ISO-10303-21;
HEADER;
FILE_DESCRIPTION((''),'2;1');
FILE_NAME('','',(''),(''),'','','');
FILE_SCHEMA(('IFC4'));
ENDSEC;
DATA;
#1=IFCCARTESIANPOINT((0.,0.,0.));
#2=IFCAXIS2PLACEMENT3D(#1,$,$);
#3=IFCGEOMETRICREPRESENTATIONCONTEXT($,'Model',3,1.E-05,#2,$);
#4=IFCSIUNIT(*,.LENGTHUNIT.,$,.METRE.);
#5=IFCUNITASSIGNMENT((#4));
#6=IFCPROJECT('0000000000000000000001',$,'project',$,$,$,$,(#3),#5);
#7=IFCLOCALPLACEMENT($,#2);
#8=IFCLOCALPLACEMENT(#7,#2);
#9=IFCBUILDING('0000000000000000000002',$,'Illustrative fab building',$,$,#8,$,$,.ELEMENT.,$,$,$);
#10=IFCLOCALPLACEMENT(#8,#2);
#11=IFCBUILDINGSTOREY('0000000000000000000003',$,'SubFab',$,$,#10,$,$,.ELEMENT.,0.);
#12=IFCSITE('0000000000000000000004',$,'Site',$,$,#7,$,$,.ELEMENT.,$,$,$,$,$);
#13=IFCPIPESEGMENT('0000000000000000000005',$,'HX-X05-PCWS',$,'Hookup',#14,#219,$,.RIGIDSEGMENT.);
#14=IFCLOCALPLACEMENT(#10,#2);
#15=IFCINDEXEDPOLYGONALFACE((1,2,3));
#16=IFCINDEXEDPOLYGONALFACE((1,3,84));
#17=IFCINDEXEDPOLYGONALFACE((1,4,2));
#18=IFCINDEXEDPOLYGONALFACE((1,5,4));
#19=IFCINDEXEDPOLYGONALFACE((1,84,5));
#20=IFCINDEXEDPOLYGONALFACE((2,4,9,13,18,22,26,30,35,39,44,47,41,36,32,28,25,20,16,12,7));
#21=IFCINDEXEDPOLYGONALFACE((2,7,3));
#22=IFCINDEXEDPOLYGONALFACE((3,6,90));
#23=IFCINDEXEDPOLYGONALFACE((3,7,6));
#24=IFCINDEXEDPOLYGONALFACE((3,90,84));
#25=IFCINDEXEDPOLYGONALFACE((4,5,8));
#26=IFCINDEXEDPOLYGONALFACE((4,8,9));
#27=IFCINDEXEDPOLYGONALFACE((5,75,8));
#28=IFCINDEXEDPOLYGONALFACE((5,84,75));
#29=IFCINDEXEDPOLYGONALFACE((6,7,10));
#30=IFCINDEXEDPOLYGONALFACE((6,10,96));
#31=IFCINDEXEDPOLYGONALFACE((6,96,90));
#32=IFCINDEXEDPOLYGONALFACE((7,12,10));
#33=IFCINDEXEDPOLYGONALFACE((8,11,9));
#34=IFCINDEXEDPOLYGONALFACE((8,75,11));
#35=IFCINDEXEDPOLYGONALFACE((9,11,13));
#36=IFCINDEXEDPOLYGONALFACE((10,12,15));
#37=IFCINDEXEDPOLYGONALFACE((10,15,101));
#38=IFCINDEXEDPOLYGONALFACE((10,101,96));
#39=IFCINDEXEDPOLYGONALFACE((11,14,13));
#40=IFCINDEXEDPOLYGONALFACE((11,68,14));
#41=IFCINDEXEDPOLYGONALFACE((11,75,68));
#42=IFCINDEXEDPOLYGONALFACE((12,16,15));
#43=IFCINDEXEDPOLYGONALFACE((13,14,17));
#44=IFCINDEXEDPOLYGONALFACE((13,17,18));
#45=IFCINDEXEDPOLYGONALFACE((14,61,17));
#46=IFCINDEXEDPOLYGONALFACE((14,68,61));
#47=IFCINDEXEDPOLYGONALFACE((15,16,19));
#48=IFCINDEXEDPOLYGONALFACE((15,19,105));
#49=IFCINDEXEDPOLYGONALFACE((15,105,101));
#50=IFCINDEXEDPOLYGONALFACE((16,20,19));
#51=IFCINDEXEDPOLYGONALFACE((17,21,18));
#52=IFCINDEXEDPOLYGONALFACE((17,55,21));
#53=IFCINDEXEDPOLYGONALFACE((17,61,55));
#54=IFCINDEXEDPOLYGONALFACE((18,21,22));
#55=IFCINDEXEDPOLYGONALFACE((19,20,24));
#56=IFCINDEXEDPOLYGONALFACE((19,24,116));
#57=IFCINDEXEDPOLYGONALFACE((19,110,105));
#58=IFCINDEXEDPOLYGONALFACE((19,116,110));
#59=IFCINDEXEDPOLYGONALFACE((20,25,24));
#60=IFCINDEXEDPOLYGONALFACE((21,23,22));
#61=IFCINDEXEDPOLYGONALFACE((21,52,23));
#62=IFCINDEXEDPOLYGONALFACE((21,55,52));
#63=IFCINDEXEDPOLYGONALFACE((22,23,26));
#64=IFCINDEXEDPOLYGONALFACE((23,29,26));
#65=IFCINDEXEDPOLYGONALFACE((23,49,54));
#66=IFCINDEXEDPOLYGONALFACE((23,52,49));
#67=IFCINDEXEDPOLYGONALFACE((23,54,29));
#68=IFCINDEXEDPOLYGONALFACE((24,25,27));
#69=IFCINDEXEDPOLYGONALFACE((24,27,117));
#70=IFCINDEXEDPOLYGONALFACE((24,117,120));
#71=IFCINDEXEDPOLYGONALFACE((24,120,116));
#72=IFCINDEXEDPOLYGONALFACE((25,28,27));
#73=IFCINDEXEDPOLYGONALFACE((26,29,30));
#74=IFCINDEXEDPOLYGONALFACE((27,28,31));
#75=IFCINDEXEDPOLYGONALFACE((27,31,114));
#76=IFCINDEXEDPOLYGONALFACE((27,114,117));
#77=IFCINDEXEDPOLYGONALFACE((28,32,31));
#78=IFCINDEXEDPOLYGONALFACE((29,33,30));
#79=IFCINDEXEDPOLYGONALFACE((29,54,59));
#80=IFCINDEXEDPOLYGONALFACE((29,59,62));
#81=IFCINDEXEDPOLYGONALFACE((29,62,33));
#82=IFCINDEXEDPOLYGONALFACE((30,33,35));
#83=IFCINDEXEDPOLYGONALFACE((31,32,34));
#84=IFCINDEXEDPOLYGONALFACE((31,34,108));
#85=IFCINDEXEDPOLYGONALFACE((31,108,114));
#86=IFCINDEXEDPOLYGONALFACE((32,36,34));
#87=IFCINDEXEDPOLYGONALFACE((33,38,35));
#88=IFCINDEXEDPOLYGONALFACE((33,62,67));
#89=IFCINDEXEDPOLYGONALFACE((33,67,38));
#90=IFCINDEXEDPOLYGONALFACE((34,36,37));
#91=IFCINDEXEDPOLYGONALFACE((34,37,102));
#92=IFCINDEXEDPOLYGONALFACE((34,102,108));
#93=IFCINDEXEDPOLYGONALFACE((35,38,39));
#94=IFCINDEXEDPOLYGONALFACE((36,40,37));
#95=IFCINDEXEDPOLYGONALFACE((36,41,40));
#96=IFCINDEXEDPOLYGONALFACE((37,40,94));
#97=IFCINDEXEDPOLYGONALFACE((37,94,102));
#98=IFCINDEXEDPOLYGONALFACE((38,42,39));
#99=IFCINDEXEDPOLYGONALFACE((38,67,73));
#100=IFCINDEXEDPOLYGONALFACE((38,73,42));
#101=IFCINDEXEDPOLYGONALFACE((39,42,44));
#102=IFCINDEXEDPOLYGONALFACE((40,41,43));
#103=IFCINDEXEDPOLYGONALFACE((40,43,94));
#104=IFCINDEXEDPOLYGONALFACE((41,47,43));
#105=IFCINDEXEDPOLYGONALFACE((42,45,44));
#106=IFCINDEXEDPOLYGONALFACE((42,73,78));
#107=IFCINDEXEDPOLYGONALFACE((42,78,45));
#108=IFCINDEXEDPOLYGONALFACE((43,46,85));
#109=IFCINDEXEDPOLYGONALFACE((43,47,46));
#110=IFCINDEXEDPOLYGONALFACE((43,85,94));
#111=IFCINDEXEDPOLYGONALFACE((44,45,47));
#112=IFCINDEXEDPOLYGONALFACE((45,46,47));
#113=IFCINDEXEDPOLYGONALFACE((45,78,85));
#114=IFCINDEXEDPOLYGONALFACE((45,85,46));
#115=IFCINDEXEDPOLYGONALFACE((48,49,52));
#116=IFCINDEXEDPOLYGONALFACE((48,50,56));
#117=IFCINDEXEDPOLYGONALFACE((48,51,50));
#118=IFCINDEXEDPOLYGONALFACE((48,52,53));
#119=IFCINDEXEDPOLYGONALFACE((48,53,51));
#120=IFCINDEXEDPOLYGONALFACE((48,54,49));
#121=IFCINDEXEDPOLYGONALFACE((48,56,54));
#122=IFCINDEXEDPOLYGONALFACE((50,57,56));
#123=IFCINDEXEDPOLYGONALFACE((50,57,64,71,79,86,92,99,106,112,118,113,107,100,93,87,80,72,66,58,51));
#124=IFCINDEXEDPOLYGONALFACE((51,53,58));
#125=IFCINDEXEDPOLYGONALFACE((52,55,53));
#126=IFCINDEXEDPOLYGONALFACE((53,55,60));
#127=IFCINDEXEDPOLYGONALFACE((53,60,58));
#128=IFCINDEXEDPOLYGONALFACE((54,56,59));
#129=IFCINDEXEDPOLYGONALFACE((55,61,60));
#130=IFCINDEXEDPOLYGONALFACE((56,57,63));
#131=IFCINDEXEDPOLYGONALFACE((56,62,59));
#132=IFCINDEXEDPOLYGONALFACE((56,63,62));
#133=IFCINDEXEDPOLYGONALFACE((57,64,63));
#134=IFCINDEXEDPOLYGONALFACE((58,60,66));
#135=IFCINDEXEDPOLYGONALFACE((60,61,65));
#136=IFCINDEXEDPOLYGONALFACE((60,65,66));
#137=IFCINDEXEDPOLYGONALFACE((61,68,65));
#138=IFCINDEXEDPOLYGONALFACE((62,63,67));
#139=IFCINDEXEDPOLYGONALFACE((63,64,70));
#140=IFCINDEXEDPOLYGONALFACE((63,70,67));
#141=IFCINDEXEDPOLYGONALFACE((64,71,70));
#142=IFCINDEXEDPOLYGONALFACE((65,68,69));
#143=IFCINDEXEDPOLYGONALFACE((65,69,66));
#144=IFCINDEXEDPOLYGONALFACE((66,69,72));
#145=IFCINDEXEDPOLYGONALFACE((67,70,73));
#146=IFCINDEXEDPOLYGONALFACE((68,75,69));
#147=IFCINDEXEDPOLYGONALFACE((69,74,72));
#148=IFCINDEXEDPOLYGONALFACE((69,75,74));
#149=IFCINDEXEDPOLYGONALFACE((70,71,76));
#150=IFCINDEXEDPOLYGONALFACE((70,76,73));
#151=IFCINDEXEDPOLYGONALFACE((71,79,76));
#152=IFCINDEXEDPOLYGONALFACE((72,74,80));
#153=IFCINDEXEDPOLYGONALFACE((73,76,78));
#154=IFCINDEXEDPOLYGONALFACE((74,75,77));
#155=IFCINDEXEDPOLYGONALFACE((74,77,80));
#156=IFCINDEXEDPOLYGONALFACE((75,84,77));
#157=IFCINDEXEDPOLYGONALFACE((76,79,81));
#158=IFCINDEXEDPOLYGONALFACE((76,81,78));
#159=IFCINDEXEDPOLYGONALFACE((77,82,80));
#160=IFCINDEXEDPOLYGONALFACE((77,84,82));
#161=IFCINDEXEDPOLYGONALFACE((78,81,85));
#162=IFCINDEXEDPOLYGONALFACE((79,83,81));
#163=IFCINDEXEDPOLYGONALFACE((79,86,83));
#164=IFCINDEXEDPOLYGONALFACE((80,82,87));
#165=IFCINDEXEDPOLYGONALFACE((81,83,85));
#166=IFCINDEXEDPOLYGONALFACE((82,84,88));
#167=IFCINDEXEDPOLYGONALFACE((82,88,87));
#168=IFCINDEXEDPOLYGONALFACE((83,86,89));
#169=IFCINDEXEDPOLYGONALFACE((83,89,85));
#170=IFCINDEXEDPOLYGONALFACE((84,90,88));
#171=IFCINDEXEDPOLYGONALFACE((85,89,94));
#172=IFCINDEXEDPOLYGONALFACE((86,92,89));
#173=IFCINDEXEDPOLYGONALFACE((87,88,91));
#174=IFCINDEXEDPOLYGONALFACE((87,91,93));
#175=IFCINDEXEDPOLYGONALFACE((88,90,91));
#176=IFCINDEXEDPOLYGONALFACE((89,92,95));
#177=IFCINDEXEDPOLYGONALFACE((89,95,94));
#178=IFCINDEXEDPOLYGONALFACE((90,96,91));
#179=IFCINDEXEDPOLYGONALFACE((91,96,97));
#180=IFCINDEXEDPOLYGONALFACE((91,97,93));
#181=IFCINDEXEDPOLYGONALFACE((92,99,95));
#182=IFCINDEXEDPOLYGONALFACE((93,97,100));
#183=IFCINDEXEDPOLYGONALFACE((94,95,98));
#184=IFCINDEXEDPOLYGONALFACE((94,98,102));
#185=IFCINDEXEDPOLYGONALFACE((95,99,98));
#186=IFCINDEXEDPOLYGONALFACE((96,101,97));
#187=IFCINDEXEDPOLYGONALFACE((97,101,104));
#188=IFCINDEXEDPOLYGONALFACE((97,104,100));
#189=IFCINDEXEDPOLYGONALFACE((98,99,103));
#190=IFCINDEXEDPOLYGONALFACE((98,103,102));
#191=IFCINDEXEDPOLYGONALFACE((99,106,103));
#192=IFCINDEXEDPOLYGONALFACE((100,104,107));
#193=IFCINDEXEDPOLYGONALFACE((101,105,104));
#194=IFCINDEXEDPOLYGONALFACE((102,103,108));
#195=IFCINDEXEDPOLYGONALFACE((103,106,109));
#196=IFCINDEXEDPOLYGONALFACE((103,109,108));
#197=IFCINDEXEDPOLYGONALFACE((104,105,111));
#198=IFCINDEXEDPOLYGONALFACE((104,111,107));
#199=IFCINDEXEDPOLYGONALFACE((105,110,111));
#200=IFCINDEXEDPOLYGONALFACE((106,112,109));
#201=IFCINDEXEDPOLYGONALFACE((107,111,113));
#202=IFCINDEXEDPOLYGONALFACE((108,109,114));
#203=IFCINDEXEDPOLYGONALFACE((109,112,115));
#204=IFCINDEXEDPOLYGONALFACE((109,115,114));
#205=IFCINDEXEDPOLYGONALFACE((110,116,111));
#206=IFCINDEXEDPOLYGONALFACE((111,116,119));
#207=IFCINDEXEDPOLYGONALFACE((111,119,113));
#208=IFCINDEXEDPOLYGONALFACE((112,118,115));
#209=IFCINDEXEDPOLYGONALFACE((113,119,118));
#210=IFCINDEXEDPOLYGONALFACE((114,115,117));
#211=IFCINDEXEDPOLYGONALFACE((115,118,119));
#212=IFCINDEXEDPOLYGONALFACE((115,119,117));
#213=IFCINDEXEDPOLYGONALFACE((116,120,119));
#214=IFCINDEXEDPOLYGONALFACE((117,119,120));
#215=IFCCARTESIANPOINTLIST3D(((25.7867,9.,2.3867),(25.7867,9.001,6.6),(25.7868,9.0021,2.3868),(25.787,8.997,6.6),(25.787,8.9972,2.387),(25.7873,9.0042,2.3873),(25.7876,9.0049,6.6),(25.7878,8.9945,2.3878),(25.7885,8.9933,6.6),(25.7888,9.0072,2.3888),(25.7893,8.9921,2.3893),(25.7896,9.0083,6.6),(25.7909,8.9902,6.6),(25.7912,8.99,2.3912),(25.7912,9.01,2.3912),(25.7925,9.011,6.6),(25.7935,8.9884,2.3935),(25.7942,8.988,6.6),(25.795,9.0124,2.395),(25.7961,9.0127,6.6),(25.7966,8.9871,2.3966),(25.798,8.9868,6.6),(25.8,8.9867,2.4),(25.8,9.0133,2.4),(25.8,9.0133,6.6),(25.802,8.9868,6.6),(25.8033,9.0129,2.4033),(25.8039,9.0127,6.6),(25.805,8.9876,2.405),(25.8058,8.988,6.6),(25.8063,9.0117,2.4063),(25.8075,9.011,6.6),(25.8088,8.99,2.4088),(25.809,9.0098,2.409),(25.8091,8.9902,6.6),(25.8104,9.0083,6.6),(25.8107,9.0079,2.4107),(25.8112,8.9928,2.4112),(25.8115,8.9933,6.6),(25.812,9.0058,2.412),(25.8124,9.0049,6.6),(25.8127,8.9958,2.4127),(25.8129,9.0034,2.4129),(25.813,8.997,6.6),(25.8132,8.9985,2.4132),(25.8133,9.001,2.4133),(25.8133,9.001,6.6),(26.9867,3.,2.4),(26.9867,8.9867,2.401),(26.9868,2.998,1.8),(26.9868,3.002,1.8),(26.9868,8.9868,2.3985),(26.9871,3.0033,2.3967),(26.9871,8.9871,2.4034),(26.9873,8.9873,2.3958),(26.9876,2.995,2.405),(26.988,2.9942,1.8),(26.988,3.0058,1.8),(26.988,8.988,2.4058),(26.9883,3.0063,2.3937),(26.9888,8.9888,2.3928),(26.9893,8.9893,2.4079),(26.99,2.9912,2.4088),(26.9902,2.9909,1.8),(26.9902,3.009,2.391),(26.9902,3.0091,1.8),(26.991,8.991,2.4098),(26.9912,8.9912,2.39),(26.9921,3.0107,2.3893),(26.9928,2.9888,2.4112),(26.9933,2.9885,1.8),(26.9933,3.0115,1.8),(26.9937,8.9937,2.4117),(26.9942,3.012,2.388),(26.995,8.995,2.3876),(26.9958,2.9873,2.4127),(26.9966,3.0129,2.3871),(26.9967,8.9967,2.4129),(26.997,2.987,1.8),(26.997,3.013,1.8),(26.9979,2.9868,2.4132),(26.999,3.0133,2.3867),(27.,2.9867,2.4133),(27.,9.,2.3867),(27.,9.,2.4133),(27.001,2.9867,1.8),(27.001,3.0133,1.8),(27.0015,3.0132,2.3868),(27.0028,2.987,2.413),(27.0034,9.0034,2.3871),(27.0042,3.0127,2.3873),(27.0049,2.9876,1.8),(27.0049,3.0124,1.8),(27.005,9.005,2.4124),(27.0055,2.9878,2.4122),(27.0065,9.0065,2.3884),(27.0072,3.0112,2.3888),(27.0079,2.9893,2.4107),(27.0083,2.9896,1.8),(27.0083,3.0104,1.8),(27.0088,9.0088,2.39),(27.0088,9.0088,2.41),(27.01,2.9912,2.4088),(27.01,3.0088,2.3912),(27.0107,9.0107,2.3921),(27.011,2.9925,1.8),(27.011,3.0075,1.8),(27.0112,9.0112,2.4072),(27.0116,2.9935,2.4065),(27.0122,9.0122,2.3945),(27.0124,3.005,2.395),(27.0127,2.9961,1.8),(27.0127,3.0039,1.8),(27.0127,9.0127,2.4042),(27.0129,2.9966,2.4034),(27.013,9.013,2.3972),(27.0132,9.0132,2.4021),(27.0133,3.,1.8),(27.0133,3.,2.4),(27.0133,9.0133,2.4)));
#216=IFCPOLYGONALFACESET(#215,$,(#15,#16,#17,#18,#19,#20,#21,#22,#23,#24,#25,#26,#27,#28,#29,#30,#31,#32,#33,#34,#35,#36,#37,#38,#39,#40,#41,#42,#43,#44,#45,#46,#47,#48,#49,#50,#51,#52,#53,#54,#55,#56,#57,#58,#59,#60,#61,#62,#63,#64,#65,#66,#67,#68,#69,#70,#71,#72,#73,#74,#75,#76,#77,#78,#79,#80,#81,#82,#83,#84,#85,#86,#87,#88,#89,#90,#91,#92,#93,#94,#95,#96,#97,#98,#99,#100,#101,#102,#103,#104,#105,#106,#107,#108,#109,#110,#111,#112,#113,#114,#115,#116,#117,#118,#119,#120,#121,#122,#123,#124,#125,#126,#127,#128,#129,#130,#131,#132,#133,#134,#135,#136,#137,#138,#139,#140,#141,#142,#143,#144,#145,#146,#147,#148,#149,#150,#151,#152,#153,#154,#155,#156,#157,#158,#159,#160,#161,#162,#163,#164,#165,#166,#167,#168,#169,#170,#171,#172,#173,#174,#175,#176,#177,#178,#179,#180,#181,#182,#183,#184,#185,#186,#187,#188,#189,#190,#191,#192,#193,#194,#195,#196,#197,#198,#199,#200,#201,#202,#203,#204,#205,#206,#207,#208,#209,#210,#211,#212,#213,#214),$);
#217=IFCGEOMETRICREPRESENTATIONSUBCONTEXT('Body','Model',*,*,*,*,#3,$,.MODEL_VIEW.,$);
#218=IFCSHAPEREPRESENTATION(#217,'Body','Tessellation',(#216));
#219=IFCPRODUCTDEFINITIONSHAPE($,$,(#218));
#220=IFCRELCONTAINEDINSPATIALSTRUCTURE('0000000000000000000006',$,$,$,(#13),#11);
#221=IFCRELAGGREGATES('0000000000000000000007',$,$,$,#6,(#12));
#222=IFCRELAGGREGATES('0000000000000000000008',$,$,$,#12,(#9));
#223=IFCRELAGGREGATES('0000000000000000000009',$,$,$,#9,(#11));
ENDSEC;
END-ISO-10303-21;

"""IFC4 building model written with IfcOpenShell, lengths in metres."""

from ifc_helpers import new_model, entity, si_unit, origin, place, context, subcontext, project, spatial, element, save


model = new_model("IFC4")

# Units and contexts
model_context = context("Model", 3, precision=1e-05, world=origin())
body_context = subcontext(model_context, "Body", "Model", "MODEL_VIEW")
ifc_project = project(units=[si_unit("LENGTHUNIT", "METRE")], contexts=[model_context])

# Site, building, storey
site_placement = place(None, origin())
site = spatial("IfcSite", under=ifc_project, at=site_placement, Name="Site", CompositionType="ELEMENT")
building_placement = place(site_placement, origin())
building = spatial("IfcBuilding", under=site, at=building_placement, Name="Illustrative fab building", CompositionType="ELEMENT")
storey_placement = place(building_placement, origin())
storey = spatial("IfcBuildingStorey", under=building, at=storey_placement, Name="SubFab", CompositionType="ELEMENT", Elevation=0.0)

# Pipe segment
pipe_segment_1_placement = place(storey_placement, origin())
element("IfcPipeSegment", 1, at=pipe_segment_1_placement, inside=storey, Name="HX-X05-PCWS", ObjectType="Hookup", PredefinedType="RIGIDSEGMENT", context=body_context, shape_type="AdvancedSweptSolid", body=[
    entity("IfcSweptDiskSolid", entity("IfcPolyline", [entity("IfcCartesianPoint", [27.0, 3.0, 1.8]), entity("IfcCartesianPoint", [27.0, 3.0, 2.4]), entity("IfcCartesianPoint", [27.0, 9.0, 2.4]), entity("IfcCartesianPoint", [25.8, 9.0, 2.4]), entity("IfcCartesianPoint", [25.8, 9.0, 6.6])]), 0.0133),
])

save(model, "model.ifc")
